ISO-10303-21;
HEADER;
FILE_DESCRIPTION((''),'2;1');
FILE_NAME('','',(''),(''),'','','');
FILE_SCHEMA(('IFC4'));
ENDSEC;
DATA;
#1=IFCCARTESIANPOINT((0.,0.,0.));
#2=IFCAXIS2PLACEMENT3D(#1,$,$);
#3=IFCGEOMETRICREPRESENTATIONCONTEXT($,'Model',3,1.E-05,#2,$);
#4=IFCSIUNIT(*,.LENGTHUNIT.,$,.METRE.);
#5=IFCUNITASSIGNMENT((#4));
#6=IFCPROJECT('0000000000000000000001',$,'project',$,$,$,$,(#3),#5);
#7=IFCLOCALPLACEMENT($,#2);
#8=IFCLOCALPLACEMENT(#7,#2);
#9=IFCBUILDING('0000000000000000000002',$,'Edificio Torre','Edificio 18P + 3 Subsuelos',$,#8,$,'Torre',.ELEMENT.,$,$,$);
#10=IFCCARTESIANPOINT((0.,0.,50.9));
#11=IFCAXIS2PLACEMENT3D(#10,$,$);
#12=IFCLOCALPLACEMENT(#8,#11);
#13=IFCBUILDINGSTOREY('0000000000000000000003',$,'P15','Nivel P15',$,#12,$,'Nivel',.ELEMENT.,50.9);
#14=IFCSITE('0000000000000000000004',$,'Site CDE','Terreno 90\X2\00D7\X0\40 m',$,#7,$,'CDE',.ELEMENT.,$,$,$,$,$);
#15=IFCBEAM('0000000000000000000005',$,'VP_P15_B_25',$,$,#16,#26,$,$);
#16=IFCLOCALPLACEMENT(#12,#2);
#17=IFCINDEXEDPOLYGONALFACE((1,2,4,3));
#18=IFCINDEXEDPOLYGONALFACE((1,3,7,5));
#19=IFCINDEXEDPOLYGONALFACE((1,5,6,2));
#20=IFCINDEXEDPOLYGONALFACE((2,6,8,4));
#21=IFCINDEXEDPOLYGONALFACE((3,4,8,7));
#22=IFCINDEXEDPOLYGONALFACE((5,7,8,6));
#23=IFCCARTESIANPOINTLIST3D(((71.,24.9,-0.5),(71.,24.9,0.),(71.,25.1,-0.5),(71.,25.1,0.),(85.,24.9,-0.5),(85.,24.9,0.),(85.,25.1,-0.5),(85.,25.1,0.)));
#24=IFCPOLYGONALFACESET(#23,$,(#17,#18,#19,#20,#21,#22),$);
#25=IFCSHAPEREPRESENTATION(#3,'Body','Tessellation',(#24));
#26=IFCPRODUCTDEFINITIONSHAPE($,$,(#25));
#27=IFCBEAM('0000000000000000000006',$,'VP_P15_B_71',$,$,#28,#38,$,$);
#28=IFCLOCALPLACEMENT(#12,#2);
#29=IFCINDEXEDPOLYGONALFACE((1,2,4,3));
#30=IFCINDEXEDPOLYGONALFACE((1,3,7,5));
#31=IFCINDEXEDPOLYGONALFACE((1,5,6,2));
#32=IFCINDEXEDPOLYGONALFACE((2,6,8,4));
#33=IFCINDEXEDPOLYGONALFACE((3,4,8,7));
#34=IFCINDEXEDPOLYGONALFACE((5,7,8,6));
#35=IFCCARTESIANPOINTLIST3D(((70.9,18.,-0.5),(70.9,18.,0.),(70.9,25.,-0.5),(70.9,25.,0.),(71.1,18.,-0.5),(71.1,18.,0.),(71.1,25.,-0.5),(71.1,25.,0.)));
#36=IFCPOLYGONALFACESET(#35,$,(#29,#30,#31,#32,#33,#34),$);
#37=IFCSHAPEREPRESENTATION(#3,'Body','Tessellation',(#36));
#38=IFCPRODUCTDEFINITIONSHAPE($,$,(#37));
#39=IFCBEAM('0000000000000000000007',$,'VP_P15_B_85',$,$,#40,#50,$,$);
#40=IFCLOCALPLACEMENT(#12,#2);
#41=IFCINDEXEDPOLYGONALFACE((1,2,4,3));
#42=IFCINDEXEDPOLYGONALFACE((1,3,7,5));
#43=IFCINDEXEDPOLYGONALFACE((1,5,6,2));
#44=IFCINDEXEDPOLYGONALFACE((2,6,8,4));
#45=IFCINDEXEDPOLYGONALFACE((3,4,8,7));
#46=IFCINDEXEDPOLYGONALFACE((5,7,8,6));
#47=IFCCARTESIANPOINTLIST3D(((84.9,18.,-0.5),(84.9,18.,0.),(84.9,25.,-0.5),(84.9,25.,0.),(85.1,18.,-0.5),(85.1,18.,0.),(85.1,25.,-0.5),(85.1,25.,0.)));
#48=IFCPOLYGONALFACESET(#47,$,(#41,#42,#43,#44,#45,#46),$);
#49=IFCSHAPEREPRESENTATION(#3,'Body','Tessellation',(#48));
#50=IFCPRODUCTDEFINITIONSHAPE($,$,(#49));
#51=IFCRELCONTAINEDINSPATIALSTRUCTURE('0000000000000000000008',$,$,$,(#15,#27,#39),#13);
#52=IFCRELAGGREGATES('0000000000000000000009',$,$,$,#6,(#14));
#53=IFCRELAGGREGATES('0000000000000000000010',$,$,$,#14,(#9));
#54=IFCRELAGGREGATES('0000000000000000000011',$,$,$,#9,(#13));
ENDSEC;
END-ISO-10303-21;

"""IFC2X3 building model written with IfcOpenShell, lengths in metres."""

from ifc_helpers import new_model, si_unit, frame, origin, origin_2d, place, context, project, spatial, rectangle, extrude, element, save


model = new_model("IFC2X3")

# Units and contexts
model_context = context("Model", 3, precision=1e-05, world=origin())
ifc_project = project(units=[si_unit("LENGTHUNIT", "METRE")], contexts=[model_context])

# Site, building, storey
site_placement = place(None, origin())
site = spatial("IfcSite", under=ifc_project, at=site_placement, Name="Site CDE", Description="Terreno 90×40 m", LongName="CDE", CompositionType="ELEMENT")
building_placement = place(site_placement, origin())
building = spatial("IfcBuilding", under=site, at=building_placement, Name="Edificio Torre", Description="Edificio 18P + 3 Subsuelos", LongName="Torre", CompositionType="ELEMENT")
storey_placement = place(building_placement, frame((0.0, 0.0, 50.9)))
storey = spatial("IfcBuildingStorey", under=building, at=storey_placement, Name="P15", Description="Nivel P15", LongName="Nivel", CompositionType="ELEMENT", Elevation=50.9)

# Beams
for number, where, name in (
    (1, (78.0, 25.0, -0.5), "VP_P15_B_25"),
):
    element("IfcBeam", number, at=place(storey_placement, frame(where)), inside=storey, Name=name, context=model_context, shape_type="SweptSolid", body=[
        extrude(rectangle(XDim=14.0, YDim=0.2, at=origin_2d()), origin(), (0.0, 0.0, 1.0), 0.5),
    ])
for number, where, name in (
    (2, (71.0, 21.5, -0.5), "VP_P15_B_71"),
    (3, (85.0, 21.5, -0.5), "VP_P15_B_85"),
):
    element("IfcBeam", number, at=place(storey_placement, frame(where)), inside=storey, Name=name, context=model_context, shape_type="SweptSolid", body=[
        extrude(rectangle(XDim=0.2, YDim=7.0, at=origin_2d()), origin(), (0.0, 0.0, 1.0), 0.5),
    ])

save(model, "model.ifc")
